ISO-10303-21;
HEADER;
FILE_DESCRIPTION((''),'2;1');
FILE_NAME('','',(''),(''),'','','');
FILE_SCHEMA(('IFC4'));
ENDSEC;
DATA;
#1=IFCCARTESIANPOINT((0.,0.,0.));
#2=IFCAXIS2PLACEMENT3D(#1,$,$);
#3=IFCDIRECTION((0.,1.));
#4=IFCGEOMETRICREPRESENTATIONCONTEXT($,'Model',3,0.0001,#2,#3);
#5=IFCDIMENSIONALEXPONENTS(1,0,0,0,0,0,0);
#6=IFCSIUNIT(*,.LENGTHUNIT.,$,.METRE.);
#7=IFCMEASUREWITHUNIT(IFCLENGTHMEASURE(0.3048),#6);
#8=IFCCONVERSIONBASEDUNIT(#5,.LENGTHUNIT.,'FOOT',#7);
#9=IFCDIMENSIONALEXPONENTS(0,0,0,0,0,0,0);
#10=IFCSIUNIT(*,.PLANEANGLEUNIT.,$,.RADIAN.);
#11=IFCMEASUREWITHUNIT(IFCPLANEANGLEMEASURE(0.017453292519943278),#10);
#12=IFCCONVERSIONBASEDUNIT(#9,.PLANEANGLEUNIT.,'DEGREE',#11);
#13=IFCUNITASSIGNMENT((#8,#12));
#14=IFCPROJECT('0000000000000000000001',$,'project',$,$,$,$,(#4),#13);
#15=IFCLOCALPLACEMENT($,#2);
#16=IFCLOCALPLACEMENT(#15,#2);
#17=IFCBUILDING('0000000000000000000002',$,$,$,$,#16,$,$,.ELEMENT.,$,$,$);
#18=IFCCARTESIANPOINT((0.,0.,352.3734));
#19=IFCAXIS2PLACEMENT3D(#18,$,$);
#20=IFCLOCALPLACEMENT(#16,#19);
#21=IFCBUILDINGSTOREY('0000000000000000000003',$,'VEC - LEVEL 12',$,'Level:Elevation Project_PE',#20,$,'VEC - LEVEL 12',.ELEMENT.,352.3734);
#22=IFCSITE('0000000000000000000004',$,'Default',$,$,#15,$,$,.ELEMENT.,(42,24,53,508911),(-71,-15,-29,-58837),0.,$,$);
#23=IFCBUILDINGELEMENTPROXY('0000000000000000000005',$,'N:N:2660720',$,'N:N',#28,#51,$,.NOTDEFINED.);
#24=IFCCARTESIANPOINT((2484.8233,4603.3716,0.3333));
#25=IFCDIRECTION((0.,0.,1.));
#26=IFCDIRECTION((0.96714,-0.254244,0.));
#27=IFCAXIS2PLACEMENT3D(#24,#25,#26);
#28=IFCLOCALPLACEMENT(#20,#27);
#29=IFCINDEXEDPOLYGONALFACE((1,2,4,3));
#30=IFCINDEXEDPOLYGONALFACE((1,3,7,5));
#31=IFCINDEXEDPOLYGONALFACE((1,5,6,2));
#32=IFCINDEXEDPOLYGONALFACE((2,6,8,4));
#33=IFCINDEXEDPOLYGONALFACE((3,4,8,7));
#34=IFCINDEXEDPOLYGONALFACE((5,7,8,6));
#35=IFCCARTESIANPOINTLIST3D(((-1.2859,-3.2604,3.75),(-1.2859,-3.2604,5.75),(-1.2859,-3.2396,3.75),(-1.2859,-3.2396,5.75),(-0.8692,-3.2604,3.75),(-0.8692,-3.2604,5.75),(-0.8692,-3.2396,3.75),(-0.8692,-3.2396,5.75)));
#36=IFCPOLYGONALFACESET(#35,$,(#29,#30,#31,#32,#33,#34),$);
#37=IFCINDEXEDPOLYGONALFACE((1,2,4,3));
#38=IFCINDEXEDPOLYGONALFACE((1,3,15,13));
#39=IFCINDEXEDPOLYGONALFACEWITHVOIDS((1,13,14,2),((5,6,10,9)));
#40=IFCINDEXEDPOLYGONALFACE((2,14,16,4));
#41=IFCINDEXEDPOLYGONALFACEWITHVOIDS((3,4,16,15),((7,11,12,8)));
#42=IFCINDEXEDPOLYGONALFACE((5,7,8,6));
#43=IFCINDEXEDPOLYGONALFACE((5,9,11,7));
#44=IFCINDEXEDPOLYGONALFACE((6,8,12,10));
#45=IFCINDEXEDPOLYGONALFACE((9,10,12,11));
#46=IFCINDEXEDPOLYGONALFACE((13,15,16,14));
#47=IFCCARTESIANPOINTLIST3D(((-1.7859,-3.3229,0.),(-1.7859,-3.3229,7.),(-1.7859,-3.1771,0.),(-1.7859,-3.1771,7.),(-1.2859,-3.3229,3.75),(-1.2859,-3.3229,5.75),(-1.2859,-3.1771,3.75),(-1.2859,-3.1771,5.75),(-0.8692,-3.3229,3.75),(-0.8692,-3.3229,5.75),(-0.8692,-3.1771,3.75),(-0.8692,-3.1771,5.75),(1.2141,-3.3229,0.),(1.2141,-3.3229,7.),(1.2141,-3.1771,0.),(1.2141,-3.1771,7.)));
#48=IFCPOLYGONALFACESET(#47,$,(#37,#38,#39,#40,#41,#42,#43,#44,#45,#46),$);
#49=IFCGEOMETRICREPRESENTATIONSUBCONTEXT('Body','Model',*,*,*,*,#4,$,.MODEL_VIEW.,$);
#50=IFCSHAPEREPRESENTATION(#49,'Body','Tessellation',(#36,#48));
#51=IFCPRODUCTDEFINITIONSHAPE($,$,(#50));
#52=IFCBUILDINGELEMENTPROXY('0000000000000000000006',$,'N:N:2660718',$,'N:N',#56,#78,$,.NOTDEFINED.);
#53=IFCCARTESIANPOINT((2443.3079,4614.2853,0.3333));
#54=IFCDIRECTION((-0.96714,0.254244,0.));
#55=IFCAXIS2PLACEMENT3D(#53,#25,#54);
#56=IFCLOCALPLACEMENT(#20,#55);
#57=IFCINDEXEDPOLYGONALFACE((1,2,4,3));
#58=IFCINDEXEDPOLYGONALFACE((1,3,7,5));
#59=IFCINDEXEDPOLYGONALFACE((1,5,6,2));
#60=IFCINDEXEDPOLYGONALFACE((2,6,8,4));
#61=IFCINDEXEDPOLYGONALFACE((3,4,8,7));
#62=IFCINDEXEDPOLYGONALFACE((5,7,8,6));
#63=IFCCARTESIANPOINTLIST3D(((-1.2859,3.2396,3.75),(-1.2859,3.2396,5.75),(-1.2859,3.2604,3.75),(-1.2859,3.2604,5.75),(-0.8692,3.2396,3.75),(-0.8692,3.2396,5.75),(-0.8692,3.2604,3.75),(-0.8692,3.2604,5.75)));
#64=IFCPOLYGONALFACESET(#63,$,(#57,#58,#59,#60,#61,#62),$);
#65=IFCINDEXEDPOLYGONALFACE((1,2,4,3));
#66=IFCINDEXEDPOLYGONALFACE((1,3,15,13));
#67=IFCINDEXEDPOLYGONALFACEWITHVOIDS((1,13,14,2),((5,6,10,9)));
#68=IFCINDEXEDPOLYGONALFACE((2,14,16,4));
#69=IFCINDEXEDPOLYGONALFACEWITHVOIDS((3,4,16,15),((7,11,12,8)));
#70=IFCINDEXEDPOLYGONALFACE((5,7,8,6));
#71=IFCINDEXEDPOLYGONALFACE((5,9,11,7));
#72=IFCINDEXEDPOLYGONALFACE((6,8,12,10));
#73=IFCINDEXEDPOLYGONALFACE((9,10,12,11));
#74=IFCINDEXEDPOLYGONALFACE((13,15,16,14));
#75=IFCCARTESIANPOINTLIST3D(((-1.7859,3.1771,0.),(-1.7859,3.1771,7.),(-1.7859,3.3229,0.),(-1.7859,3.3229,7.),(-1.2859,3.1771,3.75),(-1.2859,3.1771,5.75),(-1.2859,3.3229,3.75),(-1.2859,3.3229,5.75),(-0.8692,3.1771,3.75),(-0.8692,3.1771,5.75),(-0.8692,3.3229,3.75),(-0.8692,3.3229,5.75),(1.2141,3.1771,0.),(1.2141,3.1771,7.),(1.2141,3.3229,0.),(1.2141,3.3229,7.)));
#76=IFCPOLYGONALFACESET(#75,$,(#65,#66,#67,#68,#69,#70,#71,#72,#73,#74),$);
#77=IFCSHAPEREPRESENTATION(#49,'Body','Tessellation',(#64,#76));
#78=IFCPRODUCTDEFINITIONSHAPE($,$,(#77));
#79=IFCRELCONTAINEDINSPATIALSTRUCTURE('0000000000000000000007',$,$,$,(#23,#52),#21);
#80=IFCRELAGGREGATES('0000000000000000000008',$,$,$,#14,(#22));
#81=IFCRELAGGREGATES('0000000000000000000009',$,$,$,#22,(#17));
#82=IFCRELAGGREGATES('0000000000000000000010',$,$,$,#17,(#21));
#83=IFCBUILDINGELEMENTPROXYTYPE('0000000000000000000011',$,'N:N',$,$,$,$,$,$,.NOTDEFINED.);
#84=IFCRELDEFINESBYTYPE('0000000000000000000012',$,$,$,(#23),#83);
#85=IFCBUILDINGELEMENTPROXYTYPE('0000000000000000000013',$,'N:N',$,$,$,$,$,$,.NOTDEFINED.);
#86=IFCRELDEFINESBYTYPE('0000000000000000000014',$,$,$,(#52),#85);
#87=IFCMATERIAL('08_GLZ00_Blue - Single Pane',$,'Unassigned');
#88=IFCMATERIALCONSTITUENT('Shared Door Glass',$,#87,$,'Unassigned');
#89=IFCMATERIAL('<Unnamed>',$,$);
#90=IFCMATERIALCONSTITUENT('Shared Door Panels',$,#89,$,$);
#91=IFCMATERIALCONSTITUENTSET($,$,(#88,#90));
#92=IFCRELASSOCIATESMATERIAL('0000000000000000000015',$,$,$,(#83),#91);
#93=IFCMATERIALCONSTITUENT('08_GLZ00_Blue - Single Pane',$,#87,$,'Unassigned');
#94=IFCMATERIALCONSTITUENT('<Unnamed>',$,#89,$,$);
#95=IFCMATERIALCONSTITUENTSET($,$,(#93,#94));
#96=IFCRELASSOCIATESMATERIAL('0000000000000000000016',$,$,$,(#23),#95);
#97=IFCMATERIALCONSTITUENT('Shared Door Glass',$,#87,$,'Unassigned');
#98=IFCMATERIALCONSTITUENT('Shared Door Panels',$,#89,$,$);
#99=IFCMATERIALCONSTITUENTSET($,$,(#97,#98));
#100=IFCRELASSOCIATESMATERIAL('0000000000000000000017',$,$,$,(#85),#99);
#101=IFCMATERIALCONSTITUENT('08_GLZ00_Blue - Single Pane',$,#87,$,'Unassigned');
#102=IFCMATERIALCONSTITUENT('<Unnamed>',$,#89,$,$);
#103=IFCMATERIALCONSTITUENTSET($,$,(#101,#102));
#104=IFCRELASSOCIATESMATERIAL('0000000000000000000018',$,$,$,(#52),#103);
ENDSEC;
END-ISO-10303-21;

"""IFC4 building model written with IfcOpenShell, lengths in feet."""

from ifc_helpers import new_model, entity, si_unit, converted_unit, direction, frame, origin, place, context, subcontext, project, spatial, indexed_curve, outline, extrude, source, transform, mapped, material, constituent, constituent_set, type_object, type_shapes, element, save


model = new_model("IFC4")

# Units and contexts
model_context = context("Model", 3, precision=0.0001, world=origin(), true_north=direction((0.0, 1.0)))
body_context = subcontext(model_context, "Body", "Model", "MODEL_VIEW")
ifc_project = project(units=[converted_unit("LENGTHUNIT", "FOOT", entity("IfcLengthMeasure", 0.3048), si_unit("LENGTHUNIT", "METRE"), dimensions=[1, 0, 0, 0, 0, 0, 0]), converted_unit("PLANEANGLEUNIT", "DEGREE", entity("IfcPlaneAngleMeasure", 0.017453292519943278), si_unit("PLANEANGLEUNIT", "RADIAN"), dimensions=[0, 0, 0, 0, 0, 0, 0])], contexts=[model_context])

# Site, building, storey
site_placement = place(None, origin())
site = spatial("IfcSite", under=ifc_project, at=site_placement, Name="Default", CompositionType="ELEMENT", RefLatitude=(42, 24, 53, 508911), RefLongitude=(-71, -15, -29, -58837), RefElevation=0.0)
building_placement = place(site_placement, origin())
building = spatial("IfcBuilding", under=site, at=building_placement, CompositionType="ELEMENT")
storey_placement = place(building_placement, frame((0.0, 0.0, 352.3734)))
storey = spatial("IfcBuildingStorey", under=building, at=storey_placement, Name="VEC - LEVEL 12", ObjectType="Level:Elevation Project_PE", LongName="VEC - LEVEL 12", CompositionType="ELEMENT", Elevation=352.3734)

# Shared definitions
ifc_material_1 = material(Name="<Unnamed>")

# Building element proxies
ifc_material_2 = material(Name="08_GLZ00_Blue - Single Pane", Category="Unassigned")
ifc_constituent_1 = constituent(ifc_material_2, Name="08_GLZ00_Blue - Single Pane", Category="Unassigned")
ifc_constituent_2 = constituent(ifc_material_1, Name="<Unnamed>")
ifc_constituent_set_1 = constituent_set(constituents=[ifc_constituent_1, ifc_constituent_2])
ifc_constituent_3 = constituent(ifc_material_2, Name="Shared Door Glass", Category="Unassigned")
ifc_constituent_4 = constituent(ifc_material_1, Name="Shared Door Panels")
ifc_constituent_set_2 = constituent_set(constituents=[ifc_constituent_3, ifc_constituent_4])
building_element_proxy_type_1 = type_object("IfcBuildingElementProxyType", Name="N:N", PredefinedType="NOTDEFINED", material=ifc_constituent_set_2)
shared_shape_1 = source(origin(), body_context, "Body", "SweptSolid", [
    extrude(outline(indexed_curve([(-0.2083, -0.0104), (0.2083, -0.0104), (0.2083, 0.0104), (-0.2083, 0.0104), (-0.2083, -0.0104)], self_intersect=False)), frame((-1.0775, -3.25, 3.75), z_axis=(0.0, 0.0, 1.0), x_axis=(-1.0, 0.0, 0.0)), (0.0, 0.0, 1.0), 2.0),
    extrude(outline(indexed_curve([(-3.5, -1.5), (3.5, -1.5), (3.5, 1.5), (-3.5, 1.5), (-3.5, -1.5)], self_intersect=False), holes=[indexed_curve([(-2.25, 0.5833), (-2.25, 1.0), (-0.25, 1.0), (-0.25, 0.5833), (-2.25, 0.5833)], self_intersect=False)]), frame((-0.2859, -3.3229, 3.5), z_axis=(0.0, 1.0, 0.0), x_axis=(0.0, 0.0, -1.0)), (0.0, 0.0, 1.0), 0.1458),
])
type_shapes(building_element_proxy_type_1, [shared_shape_1])
proxy_1_placement = place(storey_placement, frame((2484.8233, 4603.3716, 0.3333), z_axis=(0.0, 0.0, 1.0), x_axis=(0.96714, -0.254244, 0.0)))
element("IfcBuildingElementProxy", 1, at=proxy_1_placement, inside=storey, type_object=building_element_proxy_type_1, material=ifc_constituent_set_1, Name="N:N:2660720", ObjectType="N:N", PredefinedType="NOTDEFINED", context=body_context, shape_type="MappedRepresentation", body=[
    mapped(shared_shape_1, transform((0.0, 0.0, 0.0), scale=1.0)),
])
ifc_constituent_5 = constituent(ifc_material_2, Name="08_GLZ00_Blue - Single Pane", Category="Unassigned")
ifc_constituent_6 = constituent(ifc_material_1, Name="<Unnamed>")
ifc_constituent_set_3 = constituent_set(constituents=[ifc_constituent_5, ifc_constituent_6])
ifc_constituent_7 = constituent(ifc_material_2, Name="Shared Door Glass", Category="Unassigned")
ifc_constituent_8 = constituent(ifc_material_1, Name="Shared Door Panels")
ifc_constituent_set_4 = constituent_set(constituents=[ifc_constituent_7, ifc_constituent_8])
building_element_proxy_type_2 = type_object("IfcBuildingElementProxyType", Name="N:N", PredefinedType="NOTDEFINED", material=ifc_constituent_set_4)
shared_shape_2 = source(origin(), body_context, "Body", "SweptSolid", [
    extrude(outline(indexed_curve([(-0.0104, -0.2083), (0.0104, -0.2083), (0.0104, 0.2083), (-0.0104, 0.2083), (-0.0104, -0.2083)], self_intersect=False)), frame((-1.0775, 3.25, 3.75), z_axis=(0.0, 0.0, 1.0), x_axis=(0.0, 1.0, 0.0)), (0.0, 0.0, 1.0), 2.0),
    extrude(outline(indexed_curve([(-3.5, -1.5), (3.5, -1.5), (3.5, 1.5), (-3.5, 1.5), (-3.5, -1.5)], self_intersect=False), holes=[indexed_curve([(-2.25, 0.5833), (-2.25, 1.0), (-0.25, 1.0), (-0.25, 0.5833), (-2.25, 0.5833)], self_intersect=False)]), frame((-0.2859, 3.1771, 3.5), z_axis=(0.0, 1.0, 0.0), x_axis=(0.0, 0.0, -1.0)), (0.0, 0.0, 1.0), 0.1458),
])
type_shapes(building_element_proxy_type_2, [shared_shape_2])
proxy_2_placement = place(storey_placement, frame((2443.3079, 4614.2853, 0.3333), z_axis=(0.0, 0.0, 1.0), x_axis=(-0.96714, 0.254244, 0.0)))
element("IfcBuildingElementProxy", 2, at=proxy_2_placement, inside=storey, type_object=building_element_proxy_type_2, material=ifc_constituent_set_3, Name="N:N:2660718", ObjectType="N:N", PredefinedType="NOTDEFINED", context=body_context, shape_type="MappedRepresentation", body=[
    mapped(shared_shape_2, transform((0.0, 0.0, 0.0), scale=1.0)),
])

save(model, "model.ifc")
